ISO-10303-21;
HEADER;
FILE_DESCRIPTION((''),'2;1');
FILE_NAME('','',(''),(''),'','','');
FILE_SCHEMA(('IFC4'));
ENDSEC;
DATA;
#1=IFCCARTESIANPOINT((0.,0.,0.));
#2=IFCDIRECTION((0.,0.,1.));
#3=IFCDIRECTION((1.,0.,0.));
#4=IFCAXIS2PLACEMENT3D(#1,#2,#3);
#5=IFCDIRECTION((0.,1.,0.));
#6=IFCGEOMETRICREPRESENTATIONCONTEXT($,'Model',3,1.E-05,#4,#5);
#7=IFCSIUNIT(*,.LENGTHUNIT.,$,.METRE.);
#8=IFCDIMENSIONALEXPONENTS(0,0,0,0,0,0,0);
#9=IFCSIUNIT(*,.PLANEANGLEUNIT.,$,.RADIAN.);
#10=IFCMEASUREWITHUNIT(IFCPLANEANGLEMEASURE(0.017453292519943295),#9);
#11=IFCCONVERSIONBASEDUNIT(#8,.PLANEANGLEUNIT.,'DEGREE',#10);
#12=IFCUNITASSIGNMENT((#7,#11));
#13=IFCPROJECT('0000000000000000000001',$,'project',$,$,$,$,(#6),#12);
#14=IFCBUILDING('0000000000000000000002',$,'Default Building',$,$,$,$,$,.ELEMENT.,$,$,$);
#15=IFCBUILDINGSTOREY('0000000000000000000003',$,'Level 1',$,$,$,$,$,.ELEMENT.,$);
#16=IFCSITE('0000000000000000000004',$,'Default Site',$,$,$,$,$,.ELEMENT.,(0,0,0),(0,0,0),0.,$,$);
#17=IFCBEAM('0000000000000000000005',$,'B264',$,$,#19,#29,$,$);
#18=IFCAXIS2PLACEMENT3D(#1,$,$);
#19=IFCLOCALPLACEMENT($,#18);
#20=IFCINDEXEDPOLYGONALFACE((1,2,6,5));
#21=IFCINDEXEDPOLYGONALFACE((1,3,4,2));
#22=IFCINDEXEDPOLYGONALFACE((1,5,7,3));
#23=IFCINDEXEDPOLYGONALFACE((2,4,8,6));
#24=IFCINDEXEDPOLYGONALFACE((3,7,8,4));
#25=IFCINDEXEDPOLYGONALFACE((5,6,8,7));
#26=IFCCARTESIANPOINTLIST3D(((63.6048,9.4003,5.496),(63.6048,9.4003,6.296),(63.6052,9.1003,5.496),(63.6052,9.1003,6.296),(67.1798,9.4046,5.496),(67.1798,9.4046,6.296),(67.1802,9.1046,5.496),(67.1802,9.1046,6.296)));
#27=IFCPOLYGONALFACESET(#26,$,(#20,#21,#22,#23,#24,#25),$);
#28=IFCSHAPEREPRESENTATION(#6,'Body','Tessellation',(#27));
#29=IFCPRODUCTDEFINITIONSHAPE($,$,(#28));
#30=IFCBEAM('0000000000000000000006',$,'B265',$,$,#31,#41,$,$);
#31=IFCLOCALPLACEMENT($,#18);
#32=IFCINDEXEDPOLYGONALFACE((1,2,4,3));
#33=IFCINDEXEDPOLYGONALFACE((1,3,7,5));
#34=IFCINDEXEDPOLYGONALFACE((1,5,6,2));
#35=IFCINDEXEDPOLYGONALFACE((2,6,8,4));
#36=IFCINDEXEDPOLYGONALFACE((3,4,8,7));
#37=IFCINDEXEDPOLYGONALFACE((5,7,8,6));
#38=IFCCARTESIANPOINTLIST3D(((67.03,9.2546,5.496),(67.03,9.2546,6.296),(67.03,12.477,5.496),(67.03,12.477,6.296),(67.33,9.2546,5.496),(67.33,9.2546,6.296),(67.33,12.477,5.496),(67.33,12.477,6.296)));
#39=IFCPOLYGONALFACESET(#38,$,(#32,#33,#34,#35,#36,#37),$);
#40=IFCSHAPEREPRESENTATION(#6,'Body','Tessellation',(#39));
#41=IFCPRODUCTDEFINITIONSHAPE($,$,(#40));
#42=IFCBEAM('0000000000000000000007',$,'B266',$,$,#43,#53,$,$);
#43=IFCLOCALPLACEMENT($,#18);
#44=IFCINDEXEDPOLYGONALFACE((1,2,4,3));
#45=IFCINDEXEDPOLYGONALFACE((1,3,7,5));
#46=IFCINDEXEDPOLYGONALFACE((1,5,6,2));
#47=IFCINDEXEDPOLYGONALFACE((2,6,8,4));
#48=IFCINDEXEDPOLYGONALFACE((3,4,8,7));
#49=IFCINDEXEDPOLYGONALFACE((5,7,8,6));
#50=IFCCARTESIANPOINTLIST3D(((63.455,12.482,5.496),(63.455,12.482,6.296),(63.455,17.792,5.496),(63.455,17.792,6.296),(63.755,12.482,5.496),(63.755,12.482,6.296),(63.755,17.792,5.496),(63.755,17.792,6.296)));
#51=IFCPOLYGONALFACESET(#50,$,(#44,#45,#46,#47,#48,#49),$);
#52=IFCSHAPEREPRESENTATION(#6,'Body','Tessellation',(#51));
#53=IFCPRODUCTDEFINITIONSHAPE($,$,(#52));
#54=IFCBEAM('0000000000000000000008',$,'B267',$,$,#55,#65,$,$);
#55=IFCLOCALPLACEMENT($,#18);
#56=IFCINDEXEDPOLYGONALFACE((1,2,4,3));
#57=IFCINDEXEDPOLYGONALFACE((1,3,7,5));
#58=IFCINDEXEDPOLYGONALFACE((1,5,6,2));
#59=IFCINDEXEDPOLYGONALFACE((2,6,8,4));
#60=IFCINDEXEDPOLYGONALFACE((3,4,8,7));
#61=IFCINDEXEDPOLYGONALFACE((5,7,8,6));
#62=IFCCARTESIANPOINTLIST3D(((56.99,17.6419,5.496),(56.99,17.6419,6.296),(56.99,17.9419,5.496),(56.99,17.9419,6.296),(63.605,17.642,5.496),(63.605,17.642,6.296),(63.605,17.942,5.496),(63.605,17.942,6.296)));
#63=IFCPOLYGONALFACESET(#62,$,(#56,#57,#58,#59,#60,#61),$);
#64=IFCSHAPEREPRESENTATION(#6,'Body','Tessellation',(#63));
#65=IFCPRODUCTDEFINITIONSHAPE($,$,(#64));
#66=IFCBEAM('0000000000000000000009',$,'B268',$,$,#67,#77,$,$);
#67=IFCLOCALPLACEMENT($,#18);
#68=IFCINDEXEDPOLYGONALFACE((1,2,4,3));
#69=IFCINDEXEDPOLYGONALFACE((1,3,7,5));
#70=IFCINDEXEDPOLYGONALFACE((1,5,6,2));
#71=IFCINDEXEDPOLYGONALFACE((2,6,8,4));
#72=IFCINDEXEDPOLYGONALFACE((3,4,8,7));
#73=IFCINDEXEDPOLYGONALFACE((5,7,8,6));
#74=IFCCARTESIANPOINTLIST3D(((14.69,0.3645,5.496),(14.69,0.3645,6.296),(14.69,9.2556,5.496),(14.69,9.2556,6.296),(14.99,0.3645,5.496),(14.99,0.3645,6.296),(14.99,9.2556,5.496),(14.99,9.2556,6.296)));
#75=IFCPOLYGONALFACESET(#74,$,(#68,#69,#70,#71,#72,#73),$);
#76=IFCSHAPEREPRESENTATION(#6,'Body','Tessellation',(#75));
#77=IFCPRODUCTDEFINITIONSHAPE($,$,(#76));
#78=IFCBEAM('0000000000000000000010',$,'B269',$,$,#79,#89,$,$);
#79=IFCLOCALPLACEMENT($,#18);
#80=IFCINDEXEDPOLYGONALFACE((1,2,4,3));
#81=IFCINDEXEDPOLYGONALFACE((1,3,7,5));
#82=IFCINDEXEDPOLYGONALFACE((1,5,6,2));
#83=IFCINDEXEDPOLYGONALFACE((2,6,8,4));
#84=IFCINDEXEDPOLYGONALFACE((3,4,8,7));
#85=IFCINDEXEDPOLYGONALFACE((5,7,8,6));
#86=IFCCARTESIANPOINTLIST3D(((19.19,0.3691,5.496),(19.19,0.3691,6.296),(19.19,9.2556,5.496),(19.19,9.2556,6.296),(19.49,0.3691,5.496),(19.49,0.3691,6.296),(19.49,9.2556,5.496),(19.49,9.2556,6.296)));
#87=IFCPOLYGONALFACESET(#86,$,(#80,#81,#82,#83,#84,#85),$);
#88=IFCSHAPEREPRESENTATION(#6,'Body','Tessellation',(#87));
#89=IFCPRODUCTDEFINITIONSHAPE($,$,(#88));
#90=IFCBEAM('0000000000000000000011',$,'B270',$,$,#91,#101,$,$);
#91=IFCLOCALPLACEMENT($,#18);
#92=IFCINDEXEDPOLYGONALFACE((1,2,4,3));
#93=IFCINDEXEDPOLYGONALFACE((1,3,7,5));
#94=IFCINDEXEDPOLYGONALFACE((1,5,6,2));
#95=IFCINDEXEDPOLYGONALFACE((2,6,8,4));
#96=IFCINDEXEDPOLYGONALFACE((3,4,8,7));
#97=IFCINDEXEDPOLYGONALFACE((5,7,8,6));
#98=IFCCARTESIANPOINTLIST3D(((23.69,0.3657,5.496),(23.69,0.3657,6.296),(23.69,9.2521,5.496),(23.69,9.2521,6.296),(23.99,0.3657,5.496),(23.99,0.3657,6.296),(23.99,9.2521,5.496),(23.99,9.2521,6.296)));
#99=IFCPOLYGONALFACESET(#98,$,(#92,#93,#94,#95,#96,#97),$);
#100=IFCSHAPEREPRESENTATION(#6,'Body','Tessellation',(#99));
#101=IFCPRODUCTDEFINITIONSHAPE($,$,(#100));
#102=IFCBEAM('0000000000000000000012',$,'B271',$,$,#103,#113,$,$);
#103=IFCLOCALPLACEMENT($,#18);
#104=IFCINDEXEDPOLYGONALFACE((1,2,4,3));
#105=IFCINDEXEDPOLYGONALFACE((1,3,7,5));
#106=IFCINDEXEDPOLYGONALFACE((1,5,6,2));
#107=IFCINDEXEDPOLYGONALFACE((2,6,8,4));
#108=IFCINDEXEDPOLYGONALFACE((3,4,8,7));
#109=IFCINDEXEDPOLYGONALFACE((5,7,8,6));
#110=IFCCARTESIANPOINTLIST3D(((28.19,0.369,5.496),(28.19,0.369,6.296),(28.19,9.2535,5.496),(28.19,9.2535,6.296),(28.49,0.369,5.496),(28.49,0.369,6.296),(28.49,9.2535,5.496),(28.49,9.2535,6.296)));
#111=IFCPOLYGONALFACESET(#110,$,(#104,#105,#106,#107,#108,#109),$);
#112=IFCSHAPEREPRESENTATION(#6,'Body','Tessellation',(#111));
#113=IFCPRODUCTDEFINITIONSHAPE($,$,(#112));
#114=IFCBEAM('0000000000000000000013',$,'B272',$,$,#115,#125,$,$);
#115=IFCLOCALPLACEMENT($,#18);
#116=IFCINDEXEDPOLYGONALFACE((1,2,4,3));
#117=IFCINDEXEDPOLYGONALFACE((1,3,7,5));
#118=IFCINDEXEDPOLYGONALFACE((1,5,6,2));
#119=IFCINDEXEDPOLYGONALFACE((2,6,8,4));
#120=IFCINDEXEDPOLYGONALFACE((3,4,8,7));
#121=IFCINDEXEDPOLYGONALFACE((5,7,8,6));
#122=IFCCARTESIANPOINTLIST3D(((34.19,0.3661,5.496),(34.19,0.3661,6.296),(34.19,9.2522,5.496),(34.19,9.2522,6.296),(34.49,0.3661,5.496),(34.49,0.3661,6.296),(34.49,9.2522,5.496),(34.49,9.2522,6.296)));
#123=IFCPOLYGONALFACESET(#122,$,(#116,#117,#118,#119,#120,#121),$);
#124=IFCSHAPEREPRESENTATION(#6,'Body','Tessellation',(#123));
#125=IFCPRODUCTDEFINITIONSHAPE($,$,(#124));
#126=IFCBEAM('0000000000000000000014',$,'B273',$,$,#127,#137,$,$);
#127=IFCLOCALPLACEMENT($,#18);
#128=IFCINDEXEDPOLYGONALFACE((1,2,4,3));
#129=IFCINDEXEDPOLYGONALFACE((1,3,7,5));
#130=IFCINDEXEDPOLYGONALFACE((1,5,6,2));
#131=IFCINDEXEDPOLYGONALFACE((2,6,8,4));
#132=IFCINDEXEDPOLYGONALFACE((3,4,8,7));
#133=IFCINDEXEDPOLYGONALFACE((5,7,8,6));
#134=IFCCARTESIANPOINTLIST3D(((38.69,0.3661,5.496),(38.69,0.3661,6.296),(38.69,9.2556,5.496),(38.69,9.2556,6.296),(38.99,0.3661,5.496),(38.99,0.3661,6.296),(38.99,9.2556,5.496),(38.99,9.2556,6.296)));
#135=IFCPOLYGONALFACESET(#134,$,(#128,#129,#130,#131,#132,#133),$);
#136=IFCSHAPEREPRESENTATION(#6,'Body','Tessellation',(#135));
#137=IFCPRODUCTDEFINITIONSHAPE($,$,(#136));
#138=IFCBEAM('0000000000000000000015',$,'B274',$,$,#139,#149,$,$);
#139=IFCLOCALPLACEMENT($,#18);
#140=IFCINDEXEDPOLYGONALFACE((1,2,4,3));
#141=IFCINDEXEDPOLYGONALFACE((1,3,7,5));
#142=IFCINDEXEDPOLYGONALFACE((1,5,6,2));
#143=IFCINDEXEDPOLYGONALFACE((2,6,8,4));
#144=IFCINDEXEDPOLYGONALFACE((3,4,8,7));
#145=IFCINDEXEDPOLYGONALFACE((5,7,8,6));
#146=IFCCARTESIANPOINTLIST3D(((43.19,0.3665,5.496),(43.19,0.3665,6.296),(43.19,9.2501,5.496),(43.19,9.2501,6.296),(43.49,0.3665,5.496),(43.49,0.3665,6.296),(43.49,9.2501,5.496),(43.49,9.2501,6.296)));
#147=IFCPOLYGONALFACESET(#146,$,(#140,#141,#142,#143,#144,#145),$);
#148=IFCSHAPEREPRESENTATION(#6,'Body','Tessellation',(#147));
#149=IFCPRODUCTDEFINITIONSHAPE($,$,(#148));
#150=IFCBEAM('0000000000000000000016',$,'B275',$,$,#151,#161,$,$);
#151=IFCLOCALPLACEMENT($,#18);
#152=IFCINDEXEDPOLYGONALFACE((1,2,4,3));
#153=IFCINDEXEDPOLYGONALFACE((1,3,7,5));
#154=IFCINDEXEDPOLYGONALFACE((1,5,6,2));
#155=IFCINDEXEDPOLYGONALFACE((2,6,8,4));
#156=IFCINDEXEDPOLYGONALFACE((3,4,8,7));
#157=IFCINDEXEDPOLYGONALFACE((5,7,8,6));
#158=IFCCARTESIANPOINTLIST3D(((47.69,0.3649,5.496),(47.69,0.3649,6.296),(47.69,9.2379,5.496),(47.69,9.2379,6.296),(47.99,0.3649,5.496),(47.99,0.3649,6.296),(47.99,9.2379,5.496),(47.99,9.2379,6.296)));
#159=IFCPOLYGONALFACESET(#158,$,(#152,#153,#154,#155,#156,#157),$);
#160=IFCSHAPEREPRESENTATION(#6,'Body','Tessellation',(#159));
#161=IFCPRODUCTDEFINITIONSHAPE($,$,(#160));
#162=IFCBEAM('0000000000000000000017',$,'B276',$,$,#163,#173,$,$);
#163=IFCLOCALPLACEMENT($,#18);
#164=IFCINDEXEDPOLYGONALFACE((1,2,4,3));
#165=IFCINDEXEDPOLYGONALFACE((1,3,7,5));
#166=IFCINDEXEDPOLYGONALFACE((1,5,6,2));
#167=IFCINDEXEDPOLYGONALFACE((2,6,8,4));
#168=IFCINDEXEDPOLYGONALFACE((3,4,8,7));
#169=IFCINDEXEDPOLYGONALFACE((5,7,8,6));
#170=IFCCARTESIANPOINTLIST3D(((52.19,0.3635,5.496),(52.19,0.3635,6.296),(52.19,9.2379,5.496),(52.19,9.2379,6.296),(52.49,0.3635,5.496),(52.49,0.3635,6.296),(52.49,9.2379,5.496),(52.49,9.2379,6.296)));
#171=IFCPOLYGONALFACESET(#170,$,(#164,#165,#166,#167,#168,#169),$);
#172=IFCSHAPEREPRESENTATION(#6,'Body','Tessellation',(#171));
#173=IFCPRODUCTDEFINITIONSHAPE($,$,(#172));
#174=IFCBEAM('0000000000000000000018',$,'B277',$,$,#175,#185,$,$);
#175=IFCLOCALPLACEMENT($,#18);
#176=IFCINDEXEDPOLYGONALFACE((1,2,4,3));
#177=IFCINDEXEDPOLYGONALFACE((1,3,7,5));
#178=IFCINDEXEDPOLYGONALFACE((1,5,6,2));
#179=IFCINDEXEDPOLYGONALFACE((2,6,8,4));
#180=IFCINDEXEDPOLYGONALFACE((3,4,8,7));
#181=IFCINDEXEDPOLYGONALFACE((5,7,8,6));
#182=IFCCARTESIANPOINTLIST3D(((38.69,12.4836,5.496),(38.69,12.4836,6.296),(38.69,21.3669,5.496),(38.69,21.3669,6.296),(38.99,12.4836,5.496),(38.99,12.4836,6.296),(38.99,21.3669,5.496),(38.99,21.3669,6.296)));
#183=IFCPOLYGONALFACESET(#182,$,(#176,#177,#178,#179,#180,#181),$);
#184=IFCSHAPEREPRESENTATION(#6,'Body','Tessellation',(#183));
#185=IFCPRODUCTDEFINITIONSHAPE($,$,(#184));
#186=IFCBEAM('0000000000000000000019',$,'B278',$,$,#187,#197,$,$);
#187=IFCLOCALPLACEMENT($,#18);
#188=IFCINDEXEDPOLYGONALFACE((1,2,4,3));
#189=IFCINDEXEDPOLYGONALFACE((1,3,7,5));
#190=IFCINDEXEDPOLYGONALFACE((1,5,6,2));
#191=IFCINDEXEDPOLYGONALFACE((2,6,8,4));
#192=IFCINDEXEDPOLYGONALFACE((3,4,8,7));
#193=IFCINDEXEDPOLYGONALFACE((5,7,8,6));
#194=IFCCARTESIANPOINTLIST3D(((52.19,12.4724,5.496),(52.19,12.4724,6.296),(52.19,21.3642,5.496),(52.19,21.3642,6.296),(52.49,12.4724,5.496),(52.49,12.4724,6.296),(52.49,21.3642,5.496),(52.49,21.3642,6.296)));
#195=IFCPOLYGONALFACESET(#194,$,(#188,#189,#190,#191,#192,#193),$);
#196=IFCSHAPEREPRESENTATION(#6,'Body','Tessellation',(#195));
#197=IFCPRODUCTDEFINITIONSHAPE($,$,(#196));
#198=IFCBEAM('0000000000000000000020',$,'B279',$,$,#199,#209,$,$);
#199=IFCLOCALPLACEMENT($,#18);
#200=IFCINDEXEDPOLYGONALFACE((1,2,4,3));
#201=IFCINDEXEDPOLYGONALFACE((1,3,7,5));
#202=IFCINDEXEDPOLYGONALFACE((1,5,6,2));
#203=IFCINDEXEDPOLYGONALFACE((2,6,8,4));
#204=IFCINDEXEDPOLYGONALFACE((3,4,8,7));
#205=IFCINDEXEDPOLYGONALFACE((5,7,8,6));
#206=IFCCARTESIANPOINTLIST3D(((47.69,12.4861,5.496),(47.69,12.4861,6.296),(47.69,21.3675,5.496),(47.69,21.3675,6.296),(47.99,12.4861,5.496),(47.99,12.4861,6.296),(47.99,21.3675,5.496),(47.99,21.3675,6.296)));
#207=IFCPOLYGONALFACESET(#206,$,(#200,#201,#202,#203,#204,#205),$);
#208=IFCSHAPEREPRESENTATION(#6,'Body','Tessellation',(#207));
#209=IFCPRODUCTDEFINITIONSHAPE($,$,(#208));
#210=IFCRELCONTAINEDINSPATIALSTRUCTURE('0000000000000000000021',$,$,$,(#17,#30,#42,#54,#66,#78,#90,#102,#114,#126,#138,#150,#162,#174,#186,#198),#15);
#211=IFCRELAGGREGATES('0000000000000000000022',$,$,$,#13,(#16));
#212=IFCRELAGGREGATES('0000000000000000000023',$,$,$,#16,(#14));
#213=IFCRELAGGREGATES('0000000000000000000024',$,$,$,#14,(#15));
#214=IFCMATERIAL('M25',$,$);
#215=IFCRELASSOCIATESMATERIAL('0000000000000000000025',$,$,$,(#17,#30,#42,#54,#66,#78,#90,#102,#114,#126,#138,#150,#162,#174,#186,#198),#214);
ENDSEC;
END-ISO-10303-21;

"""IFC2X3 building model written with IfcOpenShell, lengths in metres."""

from ifc_helpers import new_model, entity, si_unit, converted_unit, direction, frame, frame_2d, origin_with_axes, place, context, project, spatial, rectangle, extrude, material, element, save


model = new_model("IFC2X3")

# Units and contexts
model_context = context("Model", 3, precision=1e-05, world=origin_with_axes(), true_north=direction((0.0, 1.0, 0.0)))
ifc_project = project(units=[si_unit("LENGTHUNIT", "METRE"), converted_unit("PLANEANGLEUNIT", "DEGREE", entity("IfcPlaneAngleMeasure", 0.017453292519943295), si_unit("PLANEANGLEUNIT", "RADIAN"), dimensions=[0, 0, 0, 0, 0, 0, 0])], contexts=[model_context])

# Site, building, storey
site = spatial("IfcSite", under=ifc_project, Name="Default Site", CompositionType="ELEMENT", RefLatitude=(0, 0, 0), RefLongitude=(0, 0, 0), RefElevation=0.0)
building = spatial("IfcBuilding", under=site, Name="Default Building", CompositionType="ELEMENT")
storey = spatial("IfcBuildingStorey", under=building, Name="Level 1", CompositionType="ELEMENT")

# Beams
ifc_material = material(Name="M25")
placement = place(None, origin_with_axes())
element("IfcBeam", 1, at=placement, inside=storey, material=ifc_material, Name="B264", context=model_context, shape_type="SweptSolid", body=[
    extrude(rectangle(XDim=0.3, YDim=0.8, at=frame_2d((0.0, 0.0), x_axis=(0.0, 1.0, 0.0))), frame((63.605, 9.2503, 5.896), z_axis=(0.999999, 0.001188, 0.0), x_axis=(0.0, 0.0, -1.0)), (0.0, 0.0, 1.0), 3.575),
])
element("IfcBeam", 2, at=placement, inside=storey, material=ifc_material, Name="B265", context=model_context, shape_type="SweptSolid", body=[
    extrude(rectangle(XDim=0.3, YDim=0.8, at=frame_2d((0.0, 0.0), x_axis=(0.0, 1.0, 0.0))), frame((67.18, 9.2546, 5.896), z_axis=(0.0, 1.0, 0.0), x_axis=(0.0, 0.0, -1.0)), (0.0, 0.0, 1.0), 3.2224),
])
element("IfcBeam", 3, at=placement, inside=storey, material=ifc_material, Name="B266", context=model_context, shape_type="SweptSolid", body=[
    extrude(rectangle(XDim=0.3, YDim=0.8, at=frame_2d((0.0, 0.0), x_axis=(0.0, 1.0, 0.0))), frame((63.605, 12.482, 5.896), z_axis=(0.0, 1.0, 0.0), x_axis=(0.0, 0.0, -1.0)), (0.0, 0.0, 1.0), 5.3101),
])
element("IfcBeam", 4, at=placement, inside=storey, material=ifc_material, Name="B267", context=model_context, shape_type="SweptSolid", body=[
    extrude(rectangle(XDim=0.3, YDim=0.8, at=frame_2d((0.0, 0.0), x_axis=(0.0, 1.0, 0.0))), frame((56.99, 17.7919, 5.896), z_axis=(1.0, 0.00002, 0.0), x_axis=(0.0, 0.0, -1.0)), (0.0, 0.0, 1.0), 6.615),
])
element("IfcBeam", 5, at=placement, inside=storey, material=ifc_material, Name="B268", context=model_context, shape_type="SweptSolid", body=[
    extrude(rectangle(XDim=0.3, YDim=0.8, at=frame_2d((0.0, 0.0), x_axis=(0.0, 1.0, 0.0))), frame((14.84, 0.3645, 5.896), z_axis=(0.0, 1.0, 0.0), x_axis=(0.0, 0.0, -1.0)), (0.0, 0.0, 1.0), 8.891),
])
element("IfcBeam", 6, at=placement, inside=storey, material=ifc_material, Name="B269", context=model_context, shape_type="SweptSolid", body=[
    extrude(rectangle(XDim=0.3, YDim=0.8, at=frame_2d((0.0, 0.0), x_axis=(0.0, 1.0, 0.0))), frame((19.34, 0.3691, 5.896), z_axis=(0.0, 1.0, 0.0), x_axis=(0.0, 0.0, -1.0)), (0.0, 0.0, 1.0), 8.8865),
])
element("IfcBeam", 7, at=placement, inside=storey, material=ifc_material, Name="B270", context=model_context, shape_type="SweptSolid", body=[
    extrude(rectangle(XDim=0.3, YDim=0.8, at=frame_2d((0.0, 0.0), x_axis=(0.0, 1.0, 0.0))), frame((23.84, 0.3657, 5.896), z_axis=(0.0, 1.0, 0.0), x_axis=(0.0, 0.0, -1.0)), (0.0, 0.0, 1.0), 8.8864),
])
element("IfcBeam", 8, at=placement, inside=storey, material=ifc_material, Name="B271", context=model_context, shape_type="SweptSolid", body=[
    extrude(rectangle(XDim=0.3, YDim=0.8, at=frame_2d((0.0, 0.0), x_axis=(0.0, 1.0, 0.0))), frame((28.34, 0.369, 5.896), z_axis=(0.0, 1.0, 0.0), x_axis=(0.0, 0.0, -1.0)), (0.0, 0.0, 1.0), 8.8845),
])
element("IfcBeam", 9, at=placement, inside=storey, material=ifc_material, Name="B272", context=model_context, shape_type="SweptSolid", body=[
    extrude(rectangle(XDim=0.3, YDim=0.8, at=frame_2d((0.0, 0.0), x_axis=(0.0, 1.0, 0.0))), frame((34.34, 0.3661, 5.896), z_axis=(0.0, 1.0, 0.0), x_axis=(0.0, 0.0, -1.0)), (0.0, 0.0, 1.0), 8.8861),
])
element("IfcBeam", 10, at=placement, inside=storey, material=ifc_material, Name="B273", context=model_context, shape_type="SweptSolid", body=[
    extrude(rectangle(XDim=0.3, YDim=0.8, at=frame_2d((0.0, 0.0), x_axis=(0.0, 1.0, 0.0))), frame((38.84, 0.3661, 5.896), z_axis=(0.0, 1.0, 0.0), x_axis=(0.0, 0.0, -1.0)), (0.0, 0.0, 1.0), 8.8895),
])
element("IfcBeam", 11, at=placement, inside=storey, material=ifc_material, Name="B274", context=model_context, shape_type="SweptSolid", body=[
    extrude(rectangle(XDim=0.3, YDim=0.8, at=frame_2d((0.0, 0.0), x_axis=(0.0, 1.0, 0.0))), frame((43.34, 0.3665, 5.896), z_axis=(0.0, 1.0, 0.0), x_axis=(0.0, 0.0, -1.0)), (0.0, 0.0, 1.0), 8.8836),
])
element("IfcBeam", 12, at=placement, inside=storey, material=ifc_material, Name="B275", context=model_context, shape_type="SweptSolid", body=[
    extrude(rectangle(XDim=0.3, YDim=0.8, at=frame_2d((0.0, 0.0), x_axis=(0.0, 1.0, 0.0))), frame((47.84, 0.3649, 5.896), z_axis=(0.0, 1.0, 0.0), x_axis=(0.0, 0.0, -1.0)), (0.0, 0.0, 1.0), 8.873),
])
element("IfcBeam", 13, at=placement, inside=storey, material=ifc_material, Name="B276", context=model_context, shape_type="SweptSolid", body=[
    extrude(rectangle(XDim=0.3, YDim=0.8, at=frame_2d((0.0, 0.0), x_axis=(0.0, 1.0, 0.0))), frame((52.34, 0.3635, 5.896), z_axis=(0.0, 1.0, 0.0), x_axis=(0.0, 0.0, -1.0)), (0.0, 0.0, 1.0), 8.8744),
])
element("IfcBeam", 14, at=placement, inside=storey, material=ifc_material, Name="B277", context=model_context, shape_type="SweptSolid", body=[
    extrude(rectangle(XDim=0.3, YDim=0.8, at=frame_2d((0.0, 0.0), x_axis=(0.0, 1.0, 0.0))), frame((38.84, 21.3669, 5.896), z_axis=(0.0, -1.0, 0.0), x_axis=(0.0, 0.0, -1.0)), (0.0, 0.0, 1.0), 8.8833),
])
element("IfcBeam", 15, at=placement, inside=storey, material=ifc_material, Name="B278", context=model_context, shape_type="SweptSolid", body=[
    extrude(rectangle(XDim=0.3, YDim=0.8, at=frame_2d((0.0, 0.0), x_axis=(0.0, 1.0, 0.0))), frame((52.34, 12.4724, 5.896), z_axis=(0.0, 1.0, 0.0), x_axis=(0.0, 0.0, -1.0)), (0.0, 0.0, 1.0), 8.8918),
])
element("IfcBeam", 16, at=placement, inside=storey, material=ifc_material, Name="B279", context=model_context, shape_type="SweptSolid", body=[
    extrude(rectangle(XDim=0.3, YDim=0.8, at=frame_2d((0.0, 0.0), x_axis=(0.0, 1.0, 0.0))), frame((47.84, 12.4861, 5.896), z_axis=(0.0, 1.0, 0.0), x_axis=(0.0, 0.0, -1.0)), (0.0, 0.0, 1.0), 8.8814),
])

save(model, "model.ifc")
